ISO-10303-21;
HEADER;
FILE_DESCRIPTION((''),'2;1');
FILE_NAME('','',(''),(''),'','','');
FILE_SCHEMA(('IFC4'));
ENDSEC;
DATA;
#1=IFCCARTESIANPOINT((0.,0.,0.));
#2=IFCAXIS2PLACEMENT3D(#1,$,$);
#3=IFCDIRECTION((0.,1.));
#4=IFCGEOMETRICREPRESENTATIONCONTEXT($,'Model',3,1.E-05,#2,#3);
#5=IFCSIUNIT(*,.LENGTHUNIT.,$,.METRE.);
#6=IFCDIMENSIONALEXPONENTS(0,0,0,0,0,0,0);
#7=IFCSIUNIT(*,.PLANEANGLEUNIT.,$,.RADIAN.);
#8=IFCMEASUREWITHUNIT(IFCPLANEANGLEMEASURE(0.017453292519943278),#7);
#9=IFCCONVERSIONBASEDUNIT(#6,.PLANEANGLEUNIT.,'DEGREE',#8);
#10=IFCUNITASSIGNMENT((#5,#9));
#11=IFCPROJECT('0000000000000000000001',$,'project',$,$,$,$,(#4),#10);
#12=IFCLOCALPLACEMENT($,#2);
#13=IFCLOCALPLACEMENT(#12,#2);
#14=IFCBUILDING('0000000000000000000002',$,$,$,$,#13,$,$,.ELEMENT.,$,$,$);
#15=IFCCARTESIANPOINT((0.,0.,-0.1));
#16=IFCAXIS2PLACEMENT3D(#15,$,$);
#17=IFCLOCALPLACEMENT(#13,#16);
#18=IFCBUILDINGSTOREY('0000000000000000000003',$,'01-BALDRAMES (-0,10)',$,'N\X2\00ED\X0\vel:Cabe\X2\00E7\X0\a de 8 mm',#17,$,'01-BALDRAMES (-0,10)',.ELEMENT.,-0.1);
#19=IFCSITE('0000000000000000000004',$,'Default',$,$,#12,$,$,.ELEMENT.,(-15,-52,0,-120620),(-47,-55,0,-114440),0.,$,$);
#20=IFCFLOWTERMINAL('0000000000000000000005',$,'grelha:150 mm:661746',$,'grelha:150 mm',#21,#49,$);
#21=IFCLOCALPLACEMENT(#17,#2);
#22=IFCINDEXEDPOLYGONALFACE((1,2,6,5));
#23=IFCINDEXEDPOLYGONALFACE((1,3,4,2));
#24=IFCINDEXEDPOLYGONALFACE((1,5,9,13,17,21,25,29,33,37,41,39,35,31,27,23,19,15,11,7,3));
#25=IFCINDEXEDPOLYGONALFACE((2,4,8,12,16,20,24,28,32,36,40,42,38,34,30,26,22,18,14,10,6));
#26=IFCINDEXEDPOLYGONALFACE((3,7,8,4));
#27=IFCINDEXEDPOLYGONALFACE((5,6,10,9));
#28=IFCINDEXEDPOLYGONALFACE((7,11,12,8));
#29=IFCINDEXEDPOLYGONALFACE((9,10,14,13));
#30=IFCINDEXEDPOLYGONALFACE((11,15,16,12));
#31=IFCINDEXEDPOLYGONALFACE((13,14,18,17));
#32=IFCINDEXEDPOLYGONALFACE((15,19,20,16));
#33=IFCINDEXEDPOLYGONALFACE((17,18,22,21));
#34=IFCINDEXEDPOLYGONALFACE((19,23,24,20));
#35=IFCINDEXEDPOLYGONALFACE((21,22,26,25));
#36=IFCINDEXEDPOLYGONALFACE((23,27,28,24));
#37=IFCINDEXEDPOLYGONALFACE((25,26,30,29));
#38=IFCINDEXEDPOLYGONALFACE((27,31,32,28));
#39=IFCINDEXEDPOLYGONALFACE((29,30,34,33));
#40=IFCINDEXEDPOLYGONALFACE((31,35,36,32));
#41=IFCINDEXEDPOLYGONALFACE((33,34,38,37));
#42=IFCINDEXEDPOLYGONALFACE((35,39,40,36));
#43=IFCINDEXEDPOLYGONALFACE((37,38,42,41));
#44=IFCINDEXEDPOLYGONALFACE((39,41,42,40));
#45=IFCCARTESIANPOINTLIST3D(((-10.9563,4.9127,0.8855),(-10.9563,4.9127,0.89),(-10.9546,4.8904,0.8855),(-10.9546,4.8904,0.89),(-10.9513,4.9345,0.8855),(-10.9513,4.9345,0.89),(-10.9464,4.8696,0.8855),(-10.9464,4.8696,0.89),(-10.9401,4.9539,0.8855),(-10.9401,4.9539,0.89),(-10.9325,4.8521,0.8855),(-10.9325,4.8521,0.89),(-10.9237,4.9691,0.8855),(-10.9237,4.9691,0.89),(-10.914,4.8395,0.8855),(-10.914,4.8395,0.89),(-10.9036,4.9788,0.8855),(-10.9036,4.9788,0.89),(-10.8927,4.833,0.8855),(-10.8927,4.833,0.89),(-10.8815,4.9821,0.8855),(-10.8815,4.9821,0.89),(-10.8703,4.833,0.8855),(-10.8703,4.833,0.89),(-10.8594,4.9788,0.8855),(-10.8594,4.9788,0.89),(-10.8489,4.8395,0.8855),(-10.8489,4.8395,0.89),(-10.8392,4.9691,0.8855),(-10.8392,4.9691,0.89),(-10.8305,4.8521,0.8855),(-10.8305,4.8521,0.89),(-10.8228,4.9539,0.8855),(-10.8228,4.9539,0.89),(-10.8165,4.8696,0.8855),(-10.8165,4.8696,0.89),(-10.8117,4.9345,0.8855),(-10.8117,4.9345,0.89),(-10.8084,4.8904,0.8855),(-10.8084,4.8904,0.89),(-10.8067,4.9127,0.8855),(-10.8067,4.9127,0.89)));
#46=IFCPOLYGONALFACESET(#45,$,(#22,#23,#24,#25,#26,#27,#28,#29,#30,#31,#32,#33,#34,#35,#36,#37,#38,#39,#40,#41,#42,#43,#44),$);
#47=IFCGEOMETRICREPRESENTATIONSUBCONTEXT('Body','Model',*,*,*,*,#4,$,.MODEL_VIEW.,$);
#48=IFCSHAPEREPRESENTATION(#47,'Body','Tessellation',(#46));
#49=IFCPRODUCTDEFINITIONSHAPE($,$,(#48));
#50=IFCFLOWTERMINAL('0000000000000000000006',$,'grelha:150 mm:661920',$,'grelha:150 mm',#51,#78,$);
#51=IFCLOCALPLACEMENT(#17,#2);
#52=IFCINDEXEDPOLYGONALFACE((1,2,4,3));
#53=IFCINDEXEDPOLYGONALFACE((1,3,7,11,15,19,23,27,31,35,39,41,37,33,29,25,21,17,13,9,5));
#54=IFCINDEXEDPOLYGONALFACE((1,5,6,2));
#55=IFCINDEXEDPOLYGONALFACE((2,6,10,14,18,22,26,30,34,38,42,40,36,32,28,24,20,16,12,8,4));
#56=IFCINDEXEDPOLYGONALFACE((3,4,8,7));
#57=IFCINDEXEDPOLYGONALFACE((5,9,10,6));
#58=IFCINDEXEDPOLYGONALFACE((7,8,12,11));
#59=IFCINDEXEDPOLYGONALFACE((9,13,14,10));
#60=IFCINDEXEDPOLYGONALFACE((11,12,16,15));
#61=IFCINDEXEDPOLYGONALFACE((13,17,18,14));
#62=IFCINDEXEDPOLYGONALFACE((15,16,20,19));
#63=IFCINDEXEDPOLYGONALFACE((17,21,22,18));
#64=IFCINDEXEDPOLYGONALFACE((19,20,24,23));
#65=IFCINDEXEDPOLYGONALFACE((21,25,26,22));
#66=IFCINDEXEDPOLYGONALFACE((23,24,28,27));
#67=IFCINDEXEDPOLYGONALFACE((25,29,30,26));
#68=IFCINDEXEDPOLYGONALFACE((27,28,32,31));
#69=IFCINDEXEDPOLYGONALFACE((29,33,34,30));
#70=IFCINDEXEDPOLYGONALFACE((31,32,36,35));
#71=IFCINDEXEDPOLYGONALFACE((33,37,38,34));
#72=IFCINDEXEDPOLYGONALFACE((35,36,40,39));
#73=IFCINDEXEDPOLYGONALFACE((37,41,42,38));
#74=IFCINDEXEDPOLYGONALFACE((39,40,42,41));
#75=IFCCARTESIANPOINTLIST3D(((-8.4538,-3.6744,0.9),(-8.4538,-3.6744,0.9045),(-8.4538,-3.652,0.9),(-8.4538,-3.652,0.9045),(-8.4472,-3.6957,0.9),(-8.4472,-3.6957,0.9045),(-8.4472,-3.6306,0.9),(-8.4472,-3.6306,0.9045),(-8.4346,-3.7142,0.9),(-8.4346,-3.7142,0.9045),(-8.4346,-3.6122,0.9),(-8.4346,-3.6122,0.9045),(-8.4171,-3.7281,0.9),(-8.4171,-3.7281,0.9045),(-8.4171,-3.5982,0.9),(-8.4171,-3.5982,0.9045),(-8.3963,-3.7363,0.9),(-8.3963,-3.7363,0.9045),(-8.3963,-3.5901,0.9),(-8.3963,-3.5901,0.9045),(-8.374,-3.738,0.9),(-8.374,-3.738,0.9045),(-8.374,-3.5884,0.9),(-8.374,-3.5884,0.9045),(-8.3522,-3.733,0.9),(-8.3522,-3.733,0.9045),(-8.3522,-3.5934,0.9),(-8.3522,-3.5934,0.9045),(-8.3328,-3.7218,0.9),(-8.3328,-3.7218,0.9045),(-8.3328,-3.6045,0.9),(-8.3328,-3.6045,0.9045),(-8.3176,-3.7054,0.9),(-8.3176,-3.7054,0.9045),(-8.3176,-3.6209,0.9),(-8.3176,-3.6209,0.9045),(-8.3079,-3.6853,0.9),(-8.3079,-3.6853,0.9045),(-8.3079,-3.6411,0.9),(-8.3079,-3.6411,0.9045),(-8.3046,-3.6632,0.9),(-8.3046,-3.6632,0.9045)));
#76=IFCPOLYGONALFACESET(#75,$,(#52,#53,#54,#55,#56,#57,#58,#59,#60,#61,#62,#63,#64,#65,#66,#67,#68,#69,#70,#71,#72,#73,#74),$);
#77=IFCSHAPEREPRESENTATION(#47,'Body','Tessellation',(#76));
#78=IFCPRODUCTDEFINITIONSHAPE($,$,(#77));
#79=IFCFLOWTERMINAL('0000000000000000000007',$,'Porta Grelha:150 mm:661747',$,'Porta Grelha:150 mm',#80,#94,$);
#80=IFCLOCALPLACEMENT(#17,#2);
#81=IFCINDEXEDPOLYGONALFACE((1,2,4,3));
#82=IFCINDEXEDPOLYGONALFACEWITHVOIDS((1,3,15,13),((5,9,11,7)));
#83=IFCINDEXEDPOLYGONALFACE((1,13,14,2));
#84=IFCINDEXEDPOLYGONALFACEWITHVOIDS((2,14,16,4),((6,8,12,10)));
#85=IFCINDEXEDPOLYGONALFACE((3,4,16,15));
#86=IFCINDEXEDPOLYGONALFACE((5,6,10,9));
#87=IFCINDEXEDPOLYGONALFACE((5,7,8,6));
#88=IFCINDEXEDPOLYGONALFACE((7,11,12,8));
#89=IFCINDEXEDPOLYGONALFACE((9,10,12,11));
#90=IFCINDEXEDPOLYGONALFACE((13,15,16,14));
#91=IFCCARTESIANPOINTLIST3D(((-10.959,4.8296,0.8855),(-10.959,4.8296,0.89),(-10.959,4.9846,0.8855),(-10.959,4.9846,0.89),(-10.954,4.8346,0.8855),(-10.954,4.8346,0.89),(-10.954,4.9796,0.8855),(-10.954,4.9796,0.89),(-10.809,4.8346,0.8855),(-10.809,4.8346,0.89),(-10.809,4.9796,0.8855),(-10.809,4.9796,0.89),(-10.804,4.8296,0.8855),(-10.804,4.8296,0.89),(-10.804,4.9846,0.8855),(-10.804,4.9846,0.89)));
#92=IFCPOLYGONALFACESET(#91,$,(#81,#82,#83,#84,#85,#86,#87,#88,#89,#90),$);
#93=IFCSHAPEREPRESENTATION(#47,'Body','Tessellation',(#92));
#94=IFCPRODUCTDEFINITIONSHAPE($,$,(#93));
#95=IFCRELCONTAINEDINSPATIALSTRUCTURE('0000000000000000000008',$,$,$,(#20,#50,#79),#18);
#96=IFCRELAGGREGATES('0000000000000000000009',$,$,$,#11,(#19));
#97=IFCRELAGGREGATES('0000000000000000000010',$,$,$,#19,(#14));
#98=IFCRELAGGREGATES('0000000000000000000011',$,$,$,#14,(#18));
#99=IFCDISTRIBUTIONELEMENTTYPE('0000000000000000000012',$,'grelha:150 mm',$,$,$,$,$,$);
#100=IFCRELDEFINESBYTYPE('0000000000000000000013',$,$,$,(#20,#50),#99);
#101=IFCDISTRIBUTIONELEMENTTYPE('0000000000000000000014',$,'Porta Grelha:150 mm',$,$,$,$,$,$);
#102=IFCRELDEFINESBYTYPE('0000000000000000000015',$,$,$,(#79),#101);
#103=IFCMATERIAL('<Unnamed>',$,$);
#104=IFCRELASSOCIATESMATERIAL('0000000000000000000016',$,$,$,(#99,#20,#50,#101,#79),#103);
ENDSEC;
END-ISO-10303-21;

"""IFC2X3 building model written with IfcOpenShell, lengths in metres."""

from ifc_helpers import new_model, entity, si_unit, converted_unit, direction, frame, frame_2d, origin, place, context, subcontext, project, spatial, polyline, circle, outline, extrude, source, transform, mapped, material, type_object, type_shapes, element, save


model = new_model("IFC2X3")

# Units and contexts
model_context = context("Model", 3, precision=1e-05, world=origin(), true_north=direction((0.0, 1.0)))
body_context = subcontext(model_context, "Body", "Model", "MODEL_VIEW")
ifc_project = project(units=[si_unit("LENGTHUNIT", "METRE"), converted_unit("PLANEANGLEUNIT", "DEGREE", entity("IfcPlaneAngleMeasure", 0.017453292519943278), si_unit("PLANEANGLEUNIT", "RADIAN"), dimensions=[0, 0, 0, 0, 0, 0, 0])], contexts=[model_context])

# Site, building, storey
site_placement = place(None, origin())
site = spatial("IfcSite", under=ifc_project, at=site_placement, Name="Default", CompositionType="ELEMENT", RefLatitude=(-15, -52, 0, -120620), RefLongitude=(-47, -55, 0, -114440), RefElevation=0.0)
building_placement = place(site_placement, origin())
building = spatial("IfcBuilding", under=site, at=building_placement, CompositionType="ELEMENT")
storey_placement = place(building_placement, frame((0.0, 0.0, -0.1)))
storey = spatial("IfcBuildingStorey", under=building, at=storey_placement, Name="01-BALDRAMES (-0,10)", ObjectType="Nível:Cabeça de 8 mm", LongName="01-BALDRAMES (-0,10)", CompositionType="ELEMENT", Elevation=-0.1)

# Shared definitions
ifc_material = material(Name="<Unnamed>")

# Flow terminals
distribution_element_type_1 = type_object("IfcDistributionElementType", Name="grelha:150 mm", material=ifc_material)
shared_shape_1 = source(origin(), body_context, "Body", "SweptSolid", [
    extrude(circle(Radius=0.075, at=frame_2d((0.0, 0.0), x_axis=(1.0, 0.0))), origin(), (0.0, 0.0, 1.0), 0.0045),
])
type_shapes(distribution_element_type_1, [shared_shape_1])
flow_terminal_1_placement = place(storey_placement, frame((-10.8815, 4.9071, 0.8855), z_axis=(0.0, 0.0, 1.0), x_axis=(-0.000001, 1.0, 0.0)))
element("IfcFlowTerminal", 1, at=flow_terminal_1_placement, inside=storey, type_object=distribution_element_type_1, material=ifc_material, Name="grelha:150 mm:661746", ObjectType="grelha:150 mm", context=body_context, shape_type="MappedRepresentation", body=[
    mapped(shared_shape_1, transform((0.0, 0.0, 0.0), scale=1.0)),
])
flow_terminal_2_placement = place(storey_placement, frame((-8.3796, -3.6632, 0.9)))
element("IfcFlowTerminal", 2, at=flow_terminal_2_placement, inside=storey, type_object=distribution_element_type_1, material=ifc_material, Name="grelha:150 mm:661920", ObjectType="grelha:150 mm", context=body_context, shape_type="MappedRepresentation", body=[
    mapped(shared_shape_1, transform((0.0, 0.0, 0.0), scale=1.0)),
])
distribution_element_type_2 = type_object("IfcDistributionElementType", Name="Porta Grelha:150 mm", material=ifc_material)
shared_shape_2 = source(origin(), body_context, "Body", "SweptSolid", [
    extrude(outline(polyline([(-0.0775, -0.0775), (0.0775, -0.0775), (0.0775, 0.0775), (-0.0775, 0.0775), (-0.0775, -0.0775)]), holes=[polyline([(0.0725, -0.0725), (-0.0725, -0.0725), (-0.0725, 0.0725), (0.0725, 0.0725), (0.0725, -0.0725)])]), frame((0.0, 0.0, 0.0), z_axis=(0.0, 0.0, 1.0), x_axis=(0.0, 1.0, 0.0)), (0.0, 0.0, 1.0), 0.0045),
])
type_shapes(distribution_element_type_2, [shared_shape_2])
flow_terminal_3_placement = place(storey_placement, frame((-10.8815, 4.9071, 0.8855), z_axis=(0.0, 0.0, 1.0), x_axis=(0.000001, -1.0, 0.0)))
element("IfcFlowTerminal", 3, at=flow_terminal_3_placement, inside=storey, type_object=distribution_element_type_2, material=ifc_material, Name="Porta Grelha:150 mm:661747", ObjectType="Porta Grelha:150 mm", context=body_context, shape_type="MappedRepresentation", body=[
    mapped(shared_shape_2, transform((0.0, 0.0, 0.0), scale=1.0)),
])

save(model, "model.ifc")
